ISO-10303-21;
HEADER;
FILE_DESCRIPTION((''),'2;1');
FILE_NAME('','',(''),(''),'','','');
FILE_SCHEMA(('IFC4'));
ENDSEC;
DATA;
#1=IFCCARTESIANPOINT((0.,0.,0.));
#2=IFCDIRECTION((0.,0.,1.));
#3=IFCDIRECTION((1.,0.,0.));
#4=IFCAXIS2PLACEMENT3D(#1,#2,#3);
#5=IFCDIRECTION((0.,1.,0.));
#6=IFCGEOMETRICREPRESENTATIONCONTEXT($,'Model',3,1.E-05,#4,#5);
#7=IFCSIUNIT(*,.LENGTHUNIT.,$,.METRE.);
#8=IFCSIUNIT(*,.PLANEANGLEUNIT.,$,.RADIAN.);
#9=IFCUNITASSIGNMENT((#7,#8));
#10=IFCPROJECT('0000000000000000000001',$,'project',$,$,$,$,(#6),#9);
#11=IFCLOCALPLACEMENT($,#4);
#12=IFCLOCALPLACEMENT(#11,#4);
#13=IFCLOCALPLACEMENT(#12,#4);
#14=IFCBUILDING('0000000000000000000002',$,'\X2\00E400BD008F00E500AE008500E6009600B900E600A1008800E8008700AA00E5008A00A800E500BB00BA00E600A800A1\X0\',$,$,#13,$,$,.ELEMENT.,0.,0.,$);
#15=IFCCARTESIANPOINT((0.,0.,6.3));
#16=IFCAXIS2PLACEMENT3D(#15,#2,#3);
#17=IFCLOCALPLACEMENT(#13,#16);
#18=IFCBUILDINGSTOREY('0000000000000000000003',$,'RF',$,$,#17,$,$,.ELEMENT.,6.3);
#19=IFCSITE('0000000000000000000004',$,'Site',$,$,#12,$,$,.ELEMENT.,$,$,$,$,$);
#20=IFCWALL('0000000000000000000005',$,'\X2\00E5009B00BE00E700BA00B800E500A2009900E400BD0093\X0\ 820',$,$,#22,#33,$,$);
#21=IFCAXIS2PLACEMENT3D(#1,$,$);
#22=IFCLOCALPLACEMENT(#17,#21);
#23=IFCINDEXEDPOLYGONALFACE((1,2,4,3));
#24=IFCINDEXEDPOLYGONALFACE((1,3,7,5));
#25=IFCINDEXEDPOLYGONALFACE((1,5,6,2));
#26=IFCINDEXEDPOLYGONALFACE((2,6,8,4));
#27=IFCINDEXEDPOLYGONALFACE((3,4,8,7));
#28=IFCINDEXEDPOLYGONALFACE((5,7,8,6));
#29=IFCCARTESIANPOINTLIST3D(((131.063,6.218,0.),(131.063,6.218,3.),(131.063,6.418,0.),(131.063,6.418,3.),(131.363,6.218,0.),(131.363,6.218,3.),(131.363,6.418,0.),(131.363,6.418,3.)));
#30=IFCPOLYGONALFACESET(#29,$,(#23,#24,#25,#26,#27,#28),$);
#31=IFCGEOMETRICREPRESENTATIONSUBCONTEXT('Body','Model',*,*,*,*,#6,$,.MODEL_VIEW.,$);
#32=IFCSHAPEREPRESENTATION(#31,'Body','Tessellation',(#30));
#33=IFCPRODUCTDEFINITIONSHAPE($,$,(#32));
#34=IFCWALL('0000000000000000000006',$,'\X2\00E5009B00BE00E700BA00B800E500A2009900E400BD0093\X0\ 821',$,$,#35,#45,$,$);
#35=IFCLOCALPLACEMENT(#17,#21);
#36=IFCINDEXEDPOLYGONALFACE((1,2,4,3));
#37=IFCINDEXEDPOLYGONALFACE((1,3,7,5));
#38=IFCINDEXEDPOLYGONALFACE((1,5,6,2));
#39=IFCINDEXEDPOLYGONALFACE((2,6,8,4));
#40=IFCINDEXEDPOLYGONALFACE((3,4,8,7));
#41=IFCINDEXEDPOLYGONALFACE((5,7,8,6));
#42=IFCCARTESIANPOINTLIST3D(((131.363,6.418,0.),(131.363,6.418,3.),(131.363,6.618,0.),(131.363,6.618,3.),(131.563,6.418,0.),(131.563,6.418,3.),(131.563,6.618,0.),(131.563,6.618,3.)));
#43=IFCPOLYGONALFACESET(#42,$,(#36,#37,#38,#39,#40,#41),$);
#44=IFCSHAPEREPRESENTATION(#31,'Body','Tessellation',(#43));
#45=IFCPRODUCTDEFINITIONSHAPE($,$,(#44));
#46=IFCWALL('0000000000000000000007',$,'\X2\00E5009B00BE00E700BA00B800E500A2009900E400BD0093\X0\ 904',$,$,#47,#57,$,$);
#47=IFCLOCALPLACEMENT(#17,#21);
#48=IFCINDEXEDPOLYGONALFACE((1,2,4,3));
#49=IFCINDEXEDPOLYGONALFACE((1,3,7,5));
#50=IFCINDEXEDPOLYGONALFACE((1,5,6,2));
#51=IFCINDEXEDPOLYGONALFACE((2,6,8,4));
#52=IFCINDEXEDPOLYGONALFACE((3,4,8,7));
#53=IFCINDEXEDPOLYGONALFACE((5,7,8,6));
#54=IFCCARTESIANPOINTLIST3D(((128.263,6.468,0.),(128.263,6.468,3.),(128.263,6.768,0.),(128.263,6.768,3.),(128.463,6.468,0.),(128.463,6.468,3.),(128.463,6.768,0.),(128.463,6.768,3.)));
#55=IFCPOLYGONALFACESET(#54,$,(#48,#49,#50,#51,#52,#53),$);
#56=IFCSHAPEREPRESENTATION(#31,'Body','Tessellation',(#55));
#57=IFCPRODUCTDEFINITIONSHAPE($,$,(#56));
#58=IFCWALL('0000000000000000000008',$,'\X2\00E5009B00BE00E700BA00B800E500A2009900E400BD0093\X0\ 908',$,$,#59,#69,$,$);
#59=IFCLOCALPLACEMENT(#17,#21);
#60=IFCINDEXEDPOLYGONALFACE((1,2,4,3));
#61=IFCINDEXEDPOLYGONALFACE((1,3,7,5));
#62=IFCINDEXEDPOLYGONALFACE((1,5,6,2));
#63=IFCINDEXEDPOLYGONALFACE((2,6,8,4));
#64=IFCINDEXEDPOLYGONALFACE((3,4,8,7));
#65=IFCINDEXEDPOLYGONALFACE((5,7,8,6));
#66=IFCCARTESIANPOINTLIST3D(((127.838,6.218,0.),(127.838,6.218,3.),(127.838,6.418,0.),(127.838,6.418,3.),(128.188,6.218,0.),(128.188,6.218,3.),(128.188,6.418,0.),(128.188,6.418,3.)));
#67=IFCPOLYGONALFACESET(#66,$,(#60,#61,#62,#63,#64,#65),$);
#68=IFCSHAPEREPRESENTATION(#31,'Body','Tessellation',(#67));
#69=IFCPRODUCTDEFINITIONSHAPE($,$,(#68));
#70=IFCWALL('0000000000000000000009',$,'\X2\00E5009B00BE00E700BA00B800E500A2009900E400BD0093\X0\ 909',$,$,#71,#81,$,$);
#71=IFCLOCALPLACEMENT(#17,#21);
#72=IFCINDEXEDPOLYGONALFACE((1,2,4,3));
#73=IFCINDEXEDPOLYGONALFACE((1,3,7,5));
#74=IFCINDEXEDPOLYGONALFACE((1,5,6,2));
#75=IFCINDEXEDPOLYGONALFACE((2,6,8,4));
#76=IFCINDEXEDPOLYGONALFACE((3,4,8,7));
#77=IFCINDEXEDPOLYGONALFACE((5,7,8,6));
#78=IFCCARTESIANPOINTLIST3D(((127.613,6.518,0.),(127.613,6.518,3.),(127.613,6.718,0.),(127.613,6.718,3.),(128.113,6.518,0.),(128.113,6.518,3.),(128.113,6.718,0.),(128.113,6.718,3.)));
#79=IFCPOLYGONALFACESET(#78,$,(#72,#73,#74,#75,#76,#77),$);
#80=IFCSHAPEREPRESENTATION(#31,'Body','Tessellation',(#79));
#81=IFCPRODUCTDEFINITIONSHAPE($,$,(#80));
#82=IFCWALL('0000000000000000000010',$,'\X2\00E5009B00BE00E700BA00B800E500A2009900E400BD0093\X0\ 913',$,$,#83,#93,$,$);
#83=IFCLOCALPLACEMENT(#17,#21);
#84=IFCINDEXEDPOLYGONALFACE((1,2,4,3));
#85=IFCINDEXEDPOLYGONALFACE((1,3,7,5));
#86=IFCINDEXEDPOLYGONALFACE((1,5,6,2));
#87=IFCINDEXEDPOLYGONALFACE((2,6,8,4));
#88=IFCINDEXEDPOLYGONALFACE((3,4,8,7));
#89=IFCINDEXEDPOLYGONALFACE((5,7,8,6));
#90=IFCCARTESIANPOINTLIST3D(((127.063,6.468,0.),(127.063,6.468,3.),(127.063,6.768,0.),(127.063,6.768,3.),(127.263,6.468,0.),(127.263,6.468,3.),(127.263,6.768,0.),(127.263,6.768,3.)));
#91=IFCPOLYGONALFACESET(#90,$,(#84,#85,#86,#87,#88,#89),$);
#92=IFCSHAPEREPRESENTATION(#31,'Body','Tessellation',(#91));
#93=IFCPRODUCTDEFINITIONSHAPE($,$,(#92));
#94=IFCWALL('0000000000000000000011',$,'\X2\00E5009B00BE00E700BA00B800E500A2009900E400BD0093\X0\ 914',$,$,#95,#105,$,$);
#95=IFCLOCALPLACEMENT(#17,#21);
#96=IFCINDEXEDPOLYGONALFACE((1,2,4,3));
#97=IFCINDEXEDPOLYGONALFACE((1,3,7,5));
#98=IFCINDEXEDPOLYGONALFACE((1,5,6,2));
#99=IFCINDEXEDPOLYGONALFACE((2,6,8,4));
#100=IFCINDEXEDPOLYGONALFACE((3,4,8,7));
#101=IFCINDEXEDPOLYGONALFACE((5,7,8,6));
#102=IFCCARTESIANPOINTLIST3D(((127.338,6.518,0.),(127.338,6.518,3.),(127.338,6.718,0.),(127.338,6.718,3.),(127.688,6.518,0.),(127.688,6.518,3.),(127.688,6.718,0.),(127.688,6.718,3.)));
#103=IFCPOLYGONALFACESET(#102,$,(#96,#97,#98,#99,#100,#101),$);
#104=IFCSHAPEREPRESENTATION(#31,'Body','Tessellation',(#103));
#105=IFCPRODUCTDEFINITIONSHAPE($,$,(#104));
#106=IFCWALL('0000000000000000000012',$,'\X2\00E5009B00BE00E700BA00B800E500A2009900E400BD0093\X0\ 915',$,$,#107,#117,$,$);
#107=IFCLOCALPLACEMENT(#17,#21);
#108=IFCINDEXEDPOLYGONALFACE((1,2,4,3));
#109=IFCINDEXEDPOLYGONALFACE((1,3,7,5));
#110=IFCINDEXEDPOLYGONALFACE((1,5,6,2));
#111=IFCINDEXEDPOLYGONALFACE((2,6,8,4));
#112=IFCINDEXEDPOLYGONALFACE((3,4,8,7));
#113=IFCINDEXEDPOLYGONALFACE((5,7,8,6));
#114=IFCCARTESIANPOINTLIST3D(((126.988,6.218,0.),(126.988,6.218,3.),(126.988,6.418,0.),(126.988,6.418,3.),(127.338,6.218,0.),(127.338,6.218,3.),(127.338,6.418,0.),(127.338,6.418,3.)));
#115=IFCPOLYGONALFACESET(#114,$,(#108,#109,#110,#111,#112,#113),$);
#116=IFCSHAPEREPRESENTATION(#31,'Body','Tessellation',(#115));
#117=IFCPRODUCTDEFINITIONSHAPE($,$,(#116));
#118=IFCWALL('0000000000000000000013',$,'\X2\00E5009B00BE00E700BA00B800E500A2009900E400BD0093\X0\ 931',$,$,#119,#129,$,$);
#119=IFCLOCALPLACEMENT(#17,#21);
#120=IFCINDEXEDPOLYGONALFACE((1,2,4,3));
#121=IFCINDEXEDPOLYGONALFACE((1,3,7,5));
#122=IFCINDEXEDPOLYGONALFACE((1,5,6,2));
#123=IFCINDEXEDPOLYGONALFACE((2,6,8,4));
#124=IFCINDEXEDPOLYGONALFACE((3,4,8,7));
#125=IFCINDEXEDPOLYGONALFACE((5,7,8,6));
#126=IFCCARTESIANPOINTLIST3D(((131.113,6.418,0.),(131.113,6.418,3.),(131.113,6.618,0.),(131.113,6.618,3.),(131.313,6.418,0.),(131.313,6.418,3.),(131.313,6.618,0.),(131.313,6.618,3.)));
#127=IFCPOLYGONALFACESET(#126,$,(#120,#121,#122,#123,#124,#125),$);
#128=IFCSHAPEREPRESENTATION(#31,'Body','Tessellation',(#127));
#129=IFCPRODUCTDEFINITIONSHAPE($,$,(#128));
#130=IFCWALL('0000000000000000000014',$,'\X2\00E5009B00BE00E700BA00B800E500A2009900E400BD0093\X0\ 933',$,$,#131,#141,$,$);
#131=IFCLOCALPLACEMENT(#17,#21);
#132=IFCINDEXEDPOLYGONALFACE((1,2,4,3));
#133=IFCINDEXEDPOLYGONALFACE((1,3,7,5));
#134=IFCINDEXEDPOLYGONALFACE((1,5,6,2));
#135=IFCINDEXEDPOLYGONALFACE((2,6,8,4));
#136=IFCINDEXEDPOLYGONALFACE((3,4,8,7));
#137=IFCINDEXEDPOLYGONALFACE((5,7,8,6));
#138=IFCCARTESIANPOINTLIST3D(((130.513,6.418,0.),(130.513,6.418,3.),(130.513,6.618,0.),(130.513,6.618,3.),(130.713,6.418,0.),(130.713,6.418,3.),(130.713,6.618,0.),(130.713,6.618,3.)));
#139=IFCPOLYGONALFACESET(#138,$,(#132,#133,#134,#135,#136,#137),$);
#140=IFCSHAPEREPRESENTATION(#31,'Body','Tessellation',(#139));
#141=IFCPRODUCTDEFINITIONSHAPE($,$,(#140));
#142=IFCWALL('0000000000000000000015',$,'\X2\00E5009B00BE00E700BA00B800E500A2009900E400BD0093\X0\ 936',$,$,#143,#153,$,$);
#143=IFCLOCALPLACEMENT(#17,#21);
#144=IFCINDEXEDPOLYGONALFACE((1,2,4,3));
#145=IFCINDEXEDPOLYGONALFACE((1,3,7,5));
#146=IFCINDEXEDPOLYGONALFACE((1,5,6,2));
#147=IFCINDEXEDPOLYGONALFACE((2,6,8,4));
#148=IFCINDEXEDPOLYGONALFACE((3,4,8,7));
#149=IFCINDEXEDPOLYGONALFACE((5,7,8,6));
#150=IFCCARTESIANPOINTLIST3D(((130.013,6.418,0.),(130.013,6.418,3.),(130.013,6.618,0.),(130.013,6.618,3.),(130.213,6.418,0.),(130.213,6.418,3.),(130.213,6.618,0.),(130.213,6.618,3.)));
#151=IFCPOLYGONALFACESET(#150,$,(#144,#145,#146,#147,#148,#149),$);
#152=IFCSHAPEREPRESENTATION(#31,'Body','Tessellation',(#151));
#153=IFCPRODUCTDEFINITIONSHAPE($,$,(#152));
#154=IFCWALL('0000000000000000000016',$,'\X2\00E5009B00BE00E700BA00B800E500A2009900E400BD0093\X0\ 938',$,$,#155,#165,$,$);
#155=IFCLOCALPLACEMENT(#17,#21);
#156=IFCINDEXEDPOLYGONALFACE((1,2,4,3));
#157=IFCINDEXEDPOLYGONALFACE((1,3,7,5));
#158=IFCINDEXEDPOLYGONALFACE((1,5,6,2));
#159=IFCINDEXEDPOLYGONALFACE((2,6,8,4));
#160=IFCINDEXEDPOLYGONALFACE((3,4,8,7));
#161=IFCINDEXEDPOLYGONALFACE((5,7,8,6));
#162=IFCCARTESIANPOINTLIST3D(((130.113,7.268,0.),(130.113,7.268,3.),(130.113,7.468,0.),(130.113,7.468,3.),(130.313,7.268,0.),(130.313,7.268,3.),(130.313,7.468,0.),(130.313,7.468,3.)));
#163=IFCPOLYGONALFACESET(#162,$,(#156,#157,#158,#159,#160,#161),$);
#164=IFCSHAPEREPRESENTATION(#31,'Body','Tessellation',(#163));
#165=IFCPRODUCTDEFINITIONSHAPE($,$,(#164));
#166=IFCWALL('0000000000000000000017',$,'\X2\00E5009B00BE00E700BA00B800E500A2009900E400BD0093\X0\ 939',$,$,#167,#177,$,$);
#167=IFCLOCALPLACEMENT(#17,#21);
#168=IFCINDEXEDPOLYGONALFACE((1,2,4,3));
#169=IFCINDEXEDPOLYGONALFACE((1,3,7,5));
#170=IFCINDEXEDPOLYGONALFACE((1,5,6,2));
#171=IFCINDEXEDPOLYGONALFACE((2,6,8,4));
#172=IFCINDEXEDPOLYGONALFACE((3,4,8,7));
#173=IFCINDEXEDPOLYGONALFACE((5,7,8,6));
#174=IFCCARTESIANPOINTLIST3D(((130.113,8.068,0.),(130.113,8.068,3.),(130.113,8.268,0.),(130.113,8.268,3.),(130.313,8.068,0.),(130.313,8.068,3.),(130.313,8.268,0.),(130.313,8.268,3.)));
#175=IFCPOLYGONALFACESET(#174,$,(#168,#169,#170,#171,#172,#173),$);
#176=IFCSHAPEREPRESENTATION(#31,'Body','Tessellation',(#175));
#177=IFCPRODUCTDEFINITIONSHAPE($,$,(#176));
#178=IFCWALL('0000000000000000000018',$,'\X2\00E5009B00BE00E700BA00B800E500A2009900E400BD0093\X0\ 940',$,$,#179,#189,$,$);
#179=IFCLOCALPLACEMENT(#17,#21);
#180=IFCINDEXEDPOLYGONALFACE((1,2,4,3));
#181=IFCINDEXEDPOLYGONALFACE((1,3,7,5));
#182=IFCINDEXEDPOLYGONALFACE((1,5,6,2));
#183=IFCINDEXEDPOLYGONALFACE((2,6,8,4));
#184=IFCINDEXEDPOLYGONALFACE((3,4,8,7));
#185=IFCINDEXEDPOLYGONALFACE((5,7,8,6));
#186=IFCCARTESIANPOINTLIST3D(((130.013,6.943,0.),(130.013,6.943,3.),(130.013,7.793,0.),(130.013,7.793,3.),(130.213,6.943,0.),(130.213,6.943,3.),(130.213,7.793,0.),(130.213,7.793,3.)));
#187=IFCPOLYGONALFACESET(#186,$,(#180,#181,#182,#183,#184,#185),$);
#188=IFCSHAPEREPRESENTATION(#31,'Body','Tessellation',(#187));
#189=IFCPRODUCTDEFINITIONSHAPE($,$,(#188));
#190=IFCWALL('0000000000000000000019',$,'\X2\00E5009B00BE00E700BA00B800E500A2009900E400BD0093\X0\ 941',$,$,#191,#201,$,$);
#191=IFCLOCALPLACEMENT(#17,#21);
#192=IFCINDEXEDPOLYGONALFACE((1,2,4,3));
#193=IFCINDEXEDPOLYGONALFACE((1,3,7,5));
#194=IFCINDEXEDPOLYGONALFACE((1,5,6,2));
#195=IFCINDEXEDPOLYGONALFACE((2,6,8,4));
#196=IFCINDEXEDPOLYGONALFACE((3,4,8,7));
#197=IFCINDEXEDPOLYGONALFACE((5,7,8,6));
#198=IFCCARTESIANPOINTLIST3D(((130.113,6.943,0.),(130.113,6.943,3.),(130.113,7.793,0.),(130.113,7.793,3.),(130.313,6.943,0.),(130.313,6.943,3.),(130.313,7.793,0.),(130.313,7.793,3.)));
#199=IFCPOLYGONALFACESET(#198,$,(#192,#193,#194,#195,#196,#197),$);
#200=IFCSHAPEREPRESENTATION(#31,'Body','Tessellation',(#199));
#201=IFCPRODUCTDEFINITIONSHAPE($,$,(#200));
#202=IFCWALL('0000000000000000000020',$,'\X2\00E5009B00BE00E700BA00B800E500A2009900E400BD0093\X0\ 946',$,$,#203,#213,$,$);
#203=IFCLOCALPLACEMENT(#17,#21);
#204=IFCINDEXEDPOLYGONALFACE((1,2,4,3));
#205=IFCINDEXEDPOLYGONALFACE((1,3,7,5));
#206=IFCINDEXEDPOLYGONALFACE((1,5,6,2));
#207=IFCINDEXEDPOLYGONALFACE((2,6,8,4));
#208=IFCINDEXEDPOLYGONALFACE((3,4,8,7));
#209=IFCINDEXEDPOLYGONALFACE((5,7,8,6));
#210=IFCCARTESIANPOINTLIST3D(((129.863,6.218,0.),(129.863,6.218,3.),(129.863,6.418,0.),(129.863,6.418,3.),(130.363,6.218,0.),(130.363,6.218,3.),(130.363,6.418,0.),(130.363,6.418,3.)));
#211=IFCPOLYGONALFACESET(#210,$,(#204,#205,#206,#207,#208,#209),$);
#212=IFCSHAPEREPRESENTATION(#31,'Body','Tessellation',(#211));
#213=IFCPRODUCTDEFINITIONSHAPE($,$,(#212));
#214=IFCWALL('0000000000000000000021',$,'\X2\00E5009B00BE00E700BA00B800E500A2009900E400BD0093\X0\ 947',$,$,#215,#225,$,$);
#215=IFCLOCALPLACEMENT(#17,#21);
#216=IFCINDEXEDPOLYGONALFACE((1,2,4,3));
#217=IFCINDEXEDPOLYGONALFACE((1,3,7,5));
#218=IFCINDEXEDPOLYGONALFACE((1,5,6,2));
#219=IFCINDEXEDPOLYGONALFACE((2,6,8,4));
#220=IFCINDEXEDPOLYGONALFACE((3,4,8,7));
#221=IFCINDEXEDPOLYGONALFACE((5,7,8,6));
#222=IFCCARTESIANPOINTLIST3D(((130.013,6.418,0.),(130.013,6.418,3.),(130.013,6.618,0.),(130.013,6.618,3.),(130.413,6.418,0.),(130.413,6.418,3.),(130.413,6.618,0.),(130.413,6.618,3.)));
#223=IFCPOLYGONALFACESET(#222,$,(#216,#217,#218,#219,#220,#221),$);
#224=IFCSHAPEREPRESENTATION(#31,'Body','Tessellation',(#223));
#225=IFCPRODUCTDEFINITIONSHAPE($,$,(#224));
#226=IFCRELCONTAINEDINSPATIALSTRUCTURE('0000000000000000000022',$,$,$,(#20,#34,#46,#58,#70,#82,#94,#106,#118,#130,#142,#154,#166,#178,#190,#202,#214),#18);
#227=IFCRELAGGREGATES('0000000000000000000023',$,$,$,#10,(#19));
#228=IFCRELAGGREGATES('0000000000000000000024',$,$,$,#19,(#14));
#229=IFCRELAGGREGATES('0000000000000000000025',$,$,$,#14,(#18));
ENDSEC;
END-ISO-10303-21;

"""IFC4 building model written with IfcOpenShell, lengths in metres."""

from ifc_helpers import new_model, si_unit, direction, frame, frame_2d, origin_with_axes, place, context, subcontext, project, spatial, rectangle, extrude, element, save


model = new_model("IFC4")

# Units and contexts
model_context = context("Model", 3, precision=1e-05, world=origin_with_axes(), true_north=direction((0.0, 1.0, 0.0)))
body_context = subcontext(model_context, "Body", "Model", "MODEL_VIEW")
ifc_project = project(units=[si_unit("LENGTHUNIT", "METRE"), si_unit("PLANEANGLEUNIT", "RADIAN")], contexts=[model_context])

# Site, building, storey
placement = place(None, origin_with_axes())
site_placement = place(placement, origin_with_axes())
site = spatial("IfcSite", under=ifc_project, at=site_placement, Name="Site", CompositionType="ELEMENT")
building_placement = place(site_placement, origin_with_axes())
building = spatial("IfcBuilding", under=site, at=building_placement, Name="ä½\u008få®\u0085æ\u0096¹æ¡\u0088è\u0087ªå\u008a¨å»ºæ¨¡", CompositionType="ELEMENT", ElevationOfRefHeight=0.0, ElevationOfTerrain=0.0)
storey_placement = place(building_placement, frame((0.0, 0.0, 6.3), z_axis=(0.0, 0.0, 1.0), x_axis=(1.0, 0.0, 0.0)))
storey = spatial("IfcBuildingStorey", under=building, at=storey_placement, Name="RF", CompositionType="ELEMENT", Elevation=6.3)

# Walls
wall_1_placement = place(storey_placement, frame((131.213, 6.318, 0.0), z_axis=(0.0, 0.0, 1.0), x_axis=(1.0, 0.0, 0.0)))
element("IfcWall", 1, at=wall_1_placement, inside=storey, Name="å\u009b¾çº¸å¢\u0099ä½\u0093 820", context=body_context, shape_type="SweptSolid", body=[
    extrude(rectangle(XDim=0.3, YDim=0.2, at=frame_2d((0.0, 0.0), x_axis=(1.0, 0.0, 0.0))), frame((0.0, 0.0, 0.0), z_axis=(0.0, 0.0, 1.0)), (0.0, 0.0, 1.0), 3.0),
])
wall_2_placement = place(storey_placement, frame((131.463, 6.518, 0.0), z_axis=(0.0, 0.0, 1.0), x_axis=(1.0, 0.0, 0.0)))
element("IfcWall", 2, at=wall_2_placement, inside=storey, Name="å\u009b¾çº¸å¢\u0099ä½\u0093 821", context=body_context, shape_type="SweptSolid", body=[
    extrude(rectangle(XDim=0.2, YDim=0.2, at=frame_2d((0.0, 0.0), x_axis=(1.0, 0.0, 0.0))), frame((0.0, 0.0, 0.0), z_axis=(0.0, 0.0, 1.0)), (0.0, 0.0, 1.0), 3.0),
])
wall_3_placement = place(storey_placement, frame((128.363, 6.618, 0.0), z_axis=(0.0, 0.0, 1.0), x_axis=(0.0, -1.0, 0.0)))
element("IfcWall", 3, at=wall_3_placement, inside=storey, Name="å\u009b¾çº¸å¢\u0099ä½\u0093 904", context=body_context, shape_type="SweptSolid", body=[
    extrude(rectangle(XDim=0.3, YDim=0.2, at=frame_2d((0.0, 0.0), x_axis=(1.0, 0.0, 0.0))), frame((0.0, 0.0, 0.0), z_axis=(0.0, 0.0, 1.0)), (0.0, 0.0, 1.0), 3.0),
])
wall_4_placement = place(storey_placement, frame((128.013, 6.318, 0.0), z_axis=(0.0, 0.0, 1.0), x_axis=(1.0, 0.0, 0.0)))
element("IfcWall", 4, at=wall_4_placement, inside=storey, Name="å\u009b¾çº¸å¢\u0099ä½\u0093 908", context=body_context, shape_type="SweptSolid", body=[
    extrude(rectangle(XDim=0.35, YDim=0.2, at=frame_2d((0.0, 0.0), x_axis=(1.0, 0.0, 0.0))), frame((0.0, 0.0, 0.0), z_axis=(0.0, 0.0, 1.0)), (0.0, 0.0, 1.0), 3.0),
])
wall_5_placement = place(storey_placement, frame((127.863, 6.618, 0.0), z_axis=(0.0, 0.0, 1.0), x_axis=(1.0, 0.0, 0.0)))
element("IfcWall", 5, at=wall_5_placement, inside=storey, Name="å\u009b¾çº¸å¢\u0099ä½\u0093 909", context=body_context, shape_type="SweptSolid", body=[
    extrude(rectangle(XDim=0.5, YDim=0.2, at=frame_2d((0.0, 0.0), x_axis=(1.0, 0.0, 0.0))), frame((0.0, 0.0, 0.0), z_axis=(0.0, 0.0, 1.0)), (0.0, 0.0, 1.0), 3.0),
])
wall_6_placement = place(storey_placement, frame((127.163, 6.618, 0.0), z_axis=(0.0, 0.0, 1.0), x_axis=(0.0, -1.0, 0.0)))
element("IfcWall", 6, at=wall_6_placement, inside=storey, Name="å\u009b¾çº¸å¢\u0099ä½\u0093 913", context=body_context, shape_type="SweptSolid", body=[
    extrude(rectangle(XDim=0.3, YDim=0.2, at=frame_2d((0.0, 0.0), x_axis=(1.0, 0.0, 0.0))), frame((0.0, 0.0, 0.0), z_axis=(0.0, 0.0, 1.0)), (0.0, 0.0, 1.0), 3.0),
])
for number, where, z_axis, x_axis, name in (
    (7, (127.513, 6.618, 0.0), (0.0, 0.0, 1.0), (-1.0, 0.0, 0.0), "å\u009b¾çº¸å¢\u0099ä½\u0093 914"),
    (8, (127.163, 6.318, 0.0), (0.0, 0.0, 1.0), (1.0, 0.0, 0.0), "å\u009b¾çº¸å¢\u0099ä½\u0093 915"),
):
    element("IfcWall", number, at=place(storey_placement, frame(where, z_axis=z_axis, x_axis=x_axis)), inside=storey, Name=name, context=body_context, shape_type="SweptSolid", body=[
        extrude(rectangle(XDim=0.35, YDim=0.2, at=frame_2d((0.0, 0.0), x_axis=(1.0, 0.0, 0.0))), frame((0.0, 0.0, 0.0), z_axis=(0.0, 0.0, 1.0)), (0.0, 0.0, 1.0), 3.0),
    ])
for number, where, z_axis, x_axis, name in (
    (9, (131.213, 6.518, 0.0), (0.0, 0.0, 1.0), (1.0, 0.0, 0.0), "å\u009b¾çº¸å¢\u0099ä½\u0093 931"),
    (10, (130.613, 6.518, 0.0), (0.0, 0.0, 1.0), (0.0, -1.0, 0.0), "å\u009b¾çº¸å¢\u0099ä½\u0093 933"),
    (11, (130.113, 6.518, 0.0), (0.0, 0.0, 1.0), (0.0, -1.0, 0.0), "å\u009b¾çº¸å¢\u0099ä½\u0093 936"),
    (12, (130.213, 7.368, 0.0), (0.0, 0.0, 1.0), (-1.0, 0.0, 0.0), "å\u009b¾çº¸å¢\u0099ä½\u0093 938"),
    (13, (130.213, 8.168, 0.0), (0.0, 0.0, 1.0), (-1.0, 0.0, 0.0), "å\u009b¾çº¸å¢\u0099ä½\u0093 939"),
):
    element("IfcWall", number, at=place(storey_placement, frame(where, z_axis=z_axis, x_axis=x_axis)), inside=storey, Name=name, context=body_context, shape_type="SweptSolid", body=[
        extrude(rectangle(XDim=0.2, YDim=0.2, at=frame_2d((0.0, 0.0), x_axis=(1.0, 0.0, 0.0))), frame((0.0, 0.0, 0.0), z_axis=(0.0, 0.0, 1.0)), (0.0, 0.0, 1.0), 3.0),
    ])
for number, where, z_axis, x_axis, name in (
    (14, (130.113, 7.368, 0.0), (0.0, 0.0, 1.0), (0.0, -1.0, 0.0), "å\u009b¾çº¸å¢\u0099ä½\u0093 940"),
    (15, (130.213, 7.368, 0.0), (0.0, 0.0, 1.0), (0.0, -1.0, 0.0), "å\u009b¾çº¸å¢\u0099ä½\u0093 941"),
):
    element("IfcWall", number, at=place(storey_placement, frame(where, z_axis=z_axis, x_axis=x_axis)), inside=storey, Name=name, context=body_context, shape_type="SweptSolid", body=[
        extrude(rectangle(XDim=0.85, YDim=0.2, at=frame_2d((0.0, 0.0), x_axis=(1.0, 0.0, 0.0))), frame((0.0, 0.0, 0.0), z_axis=(0.0, 0.0, 1.0)), (0.0, 0.0, 1.0), 3.0),
    ])
wall_7_placement = place(storey_placement, frame((130.113, 6.318, 0.0), z_axis=(0.0, 0.0, 1.0), x_axis=(1.0, 0.0, 0.0)))
element("IfcWall", 16, at=wall_7_placement, inside=storey, Name="å\u009b¾çº¸å¢\u0099ä½\u0093 946", context=body_context, shape_type="SweptSolid", body=[
    extrude(rectangle(XDim=0.5, YDim=0.2, at=frame_2d((0.0, 0.0), x_axis=(1.0, 0.0, 0.0))), frame((0.0, 0.0, 0.0), z_axis=(0.0, 0.0, 1.0)), (0.0, 0.0, 1.0), 3.0),
])
for number, where, z_axis, x_axis, name in (
    (17, (130.213, 6.518, 0.0), (0.0, 0.0, 1.0), (1.0, 0.0, 0.0), "å\u009b¾çº¸å¢\u0099ä½\u0093 947"),
):
    element("IfcWall", number, at=place(storey_placement, frame(where, z_axis=z_axis, x_axis=x_axis)), inside=storey, Name=name, context=body_context, shape_type="SweptSolid", body=[
        extrude(rectangle(XDim=0.4, YDim=0.2, at=frame_2d((0.0, 0.0), x_axis=(1.0, 0.0, 0.0))), frame((0.0, 0.0, 0.0), z_axis=(0.0, 0.0, 1.0)), (0.0, 0.0, 1.0), 3.0),
    ])

save(model, "model.ifc")
